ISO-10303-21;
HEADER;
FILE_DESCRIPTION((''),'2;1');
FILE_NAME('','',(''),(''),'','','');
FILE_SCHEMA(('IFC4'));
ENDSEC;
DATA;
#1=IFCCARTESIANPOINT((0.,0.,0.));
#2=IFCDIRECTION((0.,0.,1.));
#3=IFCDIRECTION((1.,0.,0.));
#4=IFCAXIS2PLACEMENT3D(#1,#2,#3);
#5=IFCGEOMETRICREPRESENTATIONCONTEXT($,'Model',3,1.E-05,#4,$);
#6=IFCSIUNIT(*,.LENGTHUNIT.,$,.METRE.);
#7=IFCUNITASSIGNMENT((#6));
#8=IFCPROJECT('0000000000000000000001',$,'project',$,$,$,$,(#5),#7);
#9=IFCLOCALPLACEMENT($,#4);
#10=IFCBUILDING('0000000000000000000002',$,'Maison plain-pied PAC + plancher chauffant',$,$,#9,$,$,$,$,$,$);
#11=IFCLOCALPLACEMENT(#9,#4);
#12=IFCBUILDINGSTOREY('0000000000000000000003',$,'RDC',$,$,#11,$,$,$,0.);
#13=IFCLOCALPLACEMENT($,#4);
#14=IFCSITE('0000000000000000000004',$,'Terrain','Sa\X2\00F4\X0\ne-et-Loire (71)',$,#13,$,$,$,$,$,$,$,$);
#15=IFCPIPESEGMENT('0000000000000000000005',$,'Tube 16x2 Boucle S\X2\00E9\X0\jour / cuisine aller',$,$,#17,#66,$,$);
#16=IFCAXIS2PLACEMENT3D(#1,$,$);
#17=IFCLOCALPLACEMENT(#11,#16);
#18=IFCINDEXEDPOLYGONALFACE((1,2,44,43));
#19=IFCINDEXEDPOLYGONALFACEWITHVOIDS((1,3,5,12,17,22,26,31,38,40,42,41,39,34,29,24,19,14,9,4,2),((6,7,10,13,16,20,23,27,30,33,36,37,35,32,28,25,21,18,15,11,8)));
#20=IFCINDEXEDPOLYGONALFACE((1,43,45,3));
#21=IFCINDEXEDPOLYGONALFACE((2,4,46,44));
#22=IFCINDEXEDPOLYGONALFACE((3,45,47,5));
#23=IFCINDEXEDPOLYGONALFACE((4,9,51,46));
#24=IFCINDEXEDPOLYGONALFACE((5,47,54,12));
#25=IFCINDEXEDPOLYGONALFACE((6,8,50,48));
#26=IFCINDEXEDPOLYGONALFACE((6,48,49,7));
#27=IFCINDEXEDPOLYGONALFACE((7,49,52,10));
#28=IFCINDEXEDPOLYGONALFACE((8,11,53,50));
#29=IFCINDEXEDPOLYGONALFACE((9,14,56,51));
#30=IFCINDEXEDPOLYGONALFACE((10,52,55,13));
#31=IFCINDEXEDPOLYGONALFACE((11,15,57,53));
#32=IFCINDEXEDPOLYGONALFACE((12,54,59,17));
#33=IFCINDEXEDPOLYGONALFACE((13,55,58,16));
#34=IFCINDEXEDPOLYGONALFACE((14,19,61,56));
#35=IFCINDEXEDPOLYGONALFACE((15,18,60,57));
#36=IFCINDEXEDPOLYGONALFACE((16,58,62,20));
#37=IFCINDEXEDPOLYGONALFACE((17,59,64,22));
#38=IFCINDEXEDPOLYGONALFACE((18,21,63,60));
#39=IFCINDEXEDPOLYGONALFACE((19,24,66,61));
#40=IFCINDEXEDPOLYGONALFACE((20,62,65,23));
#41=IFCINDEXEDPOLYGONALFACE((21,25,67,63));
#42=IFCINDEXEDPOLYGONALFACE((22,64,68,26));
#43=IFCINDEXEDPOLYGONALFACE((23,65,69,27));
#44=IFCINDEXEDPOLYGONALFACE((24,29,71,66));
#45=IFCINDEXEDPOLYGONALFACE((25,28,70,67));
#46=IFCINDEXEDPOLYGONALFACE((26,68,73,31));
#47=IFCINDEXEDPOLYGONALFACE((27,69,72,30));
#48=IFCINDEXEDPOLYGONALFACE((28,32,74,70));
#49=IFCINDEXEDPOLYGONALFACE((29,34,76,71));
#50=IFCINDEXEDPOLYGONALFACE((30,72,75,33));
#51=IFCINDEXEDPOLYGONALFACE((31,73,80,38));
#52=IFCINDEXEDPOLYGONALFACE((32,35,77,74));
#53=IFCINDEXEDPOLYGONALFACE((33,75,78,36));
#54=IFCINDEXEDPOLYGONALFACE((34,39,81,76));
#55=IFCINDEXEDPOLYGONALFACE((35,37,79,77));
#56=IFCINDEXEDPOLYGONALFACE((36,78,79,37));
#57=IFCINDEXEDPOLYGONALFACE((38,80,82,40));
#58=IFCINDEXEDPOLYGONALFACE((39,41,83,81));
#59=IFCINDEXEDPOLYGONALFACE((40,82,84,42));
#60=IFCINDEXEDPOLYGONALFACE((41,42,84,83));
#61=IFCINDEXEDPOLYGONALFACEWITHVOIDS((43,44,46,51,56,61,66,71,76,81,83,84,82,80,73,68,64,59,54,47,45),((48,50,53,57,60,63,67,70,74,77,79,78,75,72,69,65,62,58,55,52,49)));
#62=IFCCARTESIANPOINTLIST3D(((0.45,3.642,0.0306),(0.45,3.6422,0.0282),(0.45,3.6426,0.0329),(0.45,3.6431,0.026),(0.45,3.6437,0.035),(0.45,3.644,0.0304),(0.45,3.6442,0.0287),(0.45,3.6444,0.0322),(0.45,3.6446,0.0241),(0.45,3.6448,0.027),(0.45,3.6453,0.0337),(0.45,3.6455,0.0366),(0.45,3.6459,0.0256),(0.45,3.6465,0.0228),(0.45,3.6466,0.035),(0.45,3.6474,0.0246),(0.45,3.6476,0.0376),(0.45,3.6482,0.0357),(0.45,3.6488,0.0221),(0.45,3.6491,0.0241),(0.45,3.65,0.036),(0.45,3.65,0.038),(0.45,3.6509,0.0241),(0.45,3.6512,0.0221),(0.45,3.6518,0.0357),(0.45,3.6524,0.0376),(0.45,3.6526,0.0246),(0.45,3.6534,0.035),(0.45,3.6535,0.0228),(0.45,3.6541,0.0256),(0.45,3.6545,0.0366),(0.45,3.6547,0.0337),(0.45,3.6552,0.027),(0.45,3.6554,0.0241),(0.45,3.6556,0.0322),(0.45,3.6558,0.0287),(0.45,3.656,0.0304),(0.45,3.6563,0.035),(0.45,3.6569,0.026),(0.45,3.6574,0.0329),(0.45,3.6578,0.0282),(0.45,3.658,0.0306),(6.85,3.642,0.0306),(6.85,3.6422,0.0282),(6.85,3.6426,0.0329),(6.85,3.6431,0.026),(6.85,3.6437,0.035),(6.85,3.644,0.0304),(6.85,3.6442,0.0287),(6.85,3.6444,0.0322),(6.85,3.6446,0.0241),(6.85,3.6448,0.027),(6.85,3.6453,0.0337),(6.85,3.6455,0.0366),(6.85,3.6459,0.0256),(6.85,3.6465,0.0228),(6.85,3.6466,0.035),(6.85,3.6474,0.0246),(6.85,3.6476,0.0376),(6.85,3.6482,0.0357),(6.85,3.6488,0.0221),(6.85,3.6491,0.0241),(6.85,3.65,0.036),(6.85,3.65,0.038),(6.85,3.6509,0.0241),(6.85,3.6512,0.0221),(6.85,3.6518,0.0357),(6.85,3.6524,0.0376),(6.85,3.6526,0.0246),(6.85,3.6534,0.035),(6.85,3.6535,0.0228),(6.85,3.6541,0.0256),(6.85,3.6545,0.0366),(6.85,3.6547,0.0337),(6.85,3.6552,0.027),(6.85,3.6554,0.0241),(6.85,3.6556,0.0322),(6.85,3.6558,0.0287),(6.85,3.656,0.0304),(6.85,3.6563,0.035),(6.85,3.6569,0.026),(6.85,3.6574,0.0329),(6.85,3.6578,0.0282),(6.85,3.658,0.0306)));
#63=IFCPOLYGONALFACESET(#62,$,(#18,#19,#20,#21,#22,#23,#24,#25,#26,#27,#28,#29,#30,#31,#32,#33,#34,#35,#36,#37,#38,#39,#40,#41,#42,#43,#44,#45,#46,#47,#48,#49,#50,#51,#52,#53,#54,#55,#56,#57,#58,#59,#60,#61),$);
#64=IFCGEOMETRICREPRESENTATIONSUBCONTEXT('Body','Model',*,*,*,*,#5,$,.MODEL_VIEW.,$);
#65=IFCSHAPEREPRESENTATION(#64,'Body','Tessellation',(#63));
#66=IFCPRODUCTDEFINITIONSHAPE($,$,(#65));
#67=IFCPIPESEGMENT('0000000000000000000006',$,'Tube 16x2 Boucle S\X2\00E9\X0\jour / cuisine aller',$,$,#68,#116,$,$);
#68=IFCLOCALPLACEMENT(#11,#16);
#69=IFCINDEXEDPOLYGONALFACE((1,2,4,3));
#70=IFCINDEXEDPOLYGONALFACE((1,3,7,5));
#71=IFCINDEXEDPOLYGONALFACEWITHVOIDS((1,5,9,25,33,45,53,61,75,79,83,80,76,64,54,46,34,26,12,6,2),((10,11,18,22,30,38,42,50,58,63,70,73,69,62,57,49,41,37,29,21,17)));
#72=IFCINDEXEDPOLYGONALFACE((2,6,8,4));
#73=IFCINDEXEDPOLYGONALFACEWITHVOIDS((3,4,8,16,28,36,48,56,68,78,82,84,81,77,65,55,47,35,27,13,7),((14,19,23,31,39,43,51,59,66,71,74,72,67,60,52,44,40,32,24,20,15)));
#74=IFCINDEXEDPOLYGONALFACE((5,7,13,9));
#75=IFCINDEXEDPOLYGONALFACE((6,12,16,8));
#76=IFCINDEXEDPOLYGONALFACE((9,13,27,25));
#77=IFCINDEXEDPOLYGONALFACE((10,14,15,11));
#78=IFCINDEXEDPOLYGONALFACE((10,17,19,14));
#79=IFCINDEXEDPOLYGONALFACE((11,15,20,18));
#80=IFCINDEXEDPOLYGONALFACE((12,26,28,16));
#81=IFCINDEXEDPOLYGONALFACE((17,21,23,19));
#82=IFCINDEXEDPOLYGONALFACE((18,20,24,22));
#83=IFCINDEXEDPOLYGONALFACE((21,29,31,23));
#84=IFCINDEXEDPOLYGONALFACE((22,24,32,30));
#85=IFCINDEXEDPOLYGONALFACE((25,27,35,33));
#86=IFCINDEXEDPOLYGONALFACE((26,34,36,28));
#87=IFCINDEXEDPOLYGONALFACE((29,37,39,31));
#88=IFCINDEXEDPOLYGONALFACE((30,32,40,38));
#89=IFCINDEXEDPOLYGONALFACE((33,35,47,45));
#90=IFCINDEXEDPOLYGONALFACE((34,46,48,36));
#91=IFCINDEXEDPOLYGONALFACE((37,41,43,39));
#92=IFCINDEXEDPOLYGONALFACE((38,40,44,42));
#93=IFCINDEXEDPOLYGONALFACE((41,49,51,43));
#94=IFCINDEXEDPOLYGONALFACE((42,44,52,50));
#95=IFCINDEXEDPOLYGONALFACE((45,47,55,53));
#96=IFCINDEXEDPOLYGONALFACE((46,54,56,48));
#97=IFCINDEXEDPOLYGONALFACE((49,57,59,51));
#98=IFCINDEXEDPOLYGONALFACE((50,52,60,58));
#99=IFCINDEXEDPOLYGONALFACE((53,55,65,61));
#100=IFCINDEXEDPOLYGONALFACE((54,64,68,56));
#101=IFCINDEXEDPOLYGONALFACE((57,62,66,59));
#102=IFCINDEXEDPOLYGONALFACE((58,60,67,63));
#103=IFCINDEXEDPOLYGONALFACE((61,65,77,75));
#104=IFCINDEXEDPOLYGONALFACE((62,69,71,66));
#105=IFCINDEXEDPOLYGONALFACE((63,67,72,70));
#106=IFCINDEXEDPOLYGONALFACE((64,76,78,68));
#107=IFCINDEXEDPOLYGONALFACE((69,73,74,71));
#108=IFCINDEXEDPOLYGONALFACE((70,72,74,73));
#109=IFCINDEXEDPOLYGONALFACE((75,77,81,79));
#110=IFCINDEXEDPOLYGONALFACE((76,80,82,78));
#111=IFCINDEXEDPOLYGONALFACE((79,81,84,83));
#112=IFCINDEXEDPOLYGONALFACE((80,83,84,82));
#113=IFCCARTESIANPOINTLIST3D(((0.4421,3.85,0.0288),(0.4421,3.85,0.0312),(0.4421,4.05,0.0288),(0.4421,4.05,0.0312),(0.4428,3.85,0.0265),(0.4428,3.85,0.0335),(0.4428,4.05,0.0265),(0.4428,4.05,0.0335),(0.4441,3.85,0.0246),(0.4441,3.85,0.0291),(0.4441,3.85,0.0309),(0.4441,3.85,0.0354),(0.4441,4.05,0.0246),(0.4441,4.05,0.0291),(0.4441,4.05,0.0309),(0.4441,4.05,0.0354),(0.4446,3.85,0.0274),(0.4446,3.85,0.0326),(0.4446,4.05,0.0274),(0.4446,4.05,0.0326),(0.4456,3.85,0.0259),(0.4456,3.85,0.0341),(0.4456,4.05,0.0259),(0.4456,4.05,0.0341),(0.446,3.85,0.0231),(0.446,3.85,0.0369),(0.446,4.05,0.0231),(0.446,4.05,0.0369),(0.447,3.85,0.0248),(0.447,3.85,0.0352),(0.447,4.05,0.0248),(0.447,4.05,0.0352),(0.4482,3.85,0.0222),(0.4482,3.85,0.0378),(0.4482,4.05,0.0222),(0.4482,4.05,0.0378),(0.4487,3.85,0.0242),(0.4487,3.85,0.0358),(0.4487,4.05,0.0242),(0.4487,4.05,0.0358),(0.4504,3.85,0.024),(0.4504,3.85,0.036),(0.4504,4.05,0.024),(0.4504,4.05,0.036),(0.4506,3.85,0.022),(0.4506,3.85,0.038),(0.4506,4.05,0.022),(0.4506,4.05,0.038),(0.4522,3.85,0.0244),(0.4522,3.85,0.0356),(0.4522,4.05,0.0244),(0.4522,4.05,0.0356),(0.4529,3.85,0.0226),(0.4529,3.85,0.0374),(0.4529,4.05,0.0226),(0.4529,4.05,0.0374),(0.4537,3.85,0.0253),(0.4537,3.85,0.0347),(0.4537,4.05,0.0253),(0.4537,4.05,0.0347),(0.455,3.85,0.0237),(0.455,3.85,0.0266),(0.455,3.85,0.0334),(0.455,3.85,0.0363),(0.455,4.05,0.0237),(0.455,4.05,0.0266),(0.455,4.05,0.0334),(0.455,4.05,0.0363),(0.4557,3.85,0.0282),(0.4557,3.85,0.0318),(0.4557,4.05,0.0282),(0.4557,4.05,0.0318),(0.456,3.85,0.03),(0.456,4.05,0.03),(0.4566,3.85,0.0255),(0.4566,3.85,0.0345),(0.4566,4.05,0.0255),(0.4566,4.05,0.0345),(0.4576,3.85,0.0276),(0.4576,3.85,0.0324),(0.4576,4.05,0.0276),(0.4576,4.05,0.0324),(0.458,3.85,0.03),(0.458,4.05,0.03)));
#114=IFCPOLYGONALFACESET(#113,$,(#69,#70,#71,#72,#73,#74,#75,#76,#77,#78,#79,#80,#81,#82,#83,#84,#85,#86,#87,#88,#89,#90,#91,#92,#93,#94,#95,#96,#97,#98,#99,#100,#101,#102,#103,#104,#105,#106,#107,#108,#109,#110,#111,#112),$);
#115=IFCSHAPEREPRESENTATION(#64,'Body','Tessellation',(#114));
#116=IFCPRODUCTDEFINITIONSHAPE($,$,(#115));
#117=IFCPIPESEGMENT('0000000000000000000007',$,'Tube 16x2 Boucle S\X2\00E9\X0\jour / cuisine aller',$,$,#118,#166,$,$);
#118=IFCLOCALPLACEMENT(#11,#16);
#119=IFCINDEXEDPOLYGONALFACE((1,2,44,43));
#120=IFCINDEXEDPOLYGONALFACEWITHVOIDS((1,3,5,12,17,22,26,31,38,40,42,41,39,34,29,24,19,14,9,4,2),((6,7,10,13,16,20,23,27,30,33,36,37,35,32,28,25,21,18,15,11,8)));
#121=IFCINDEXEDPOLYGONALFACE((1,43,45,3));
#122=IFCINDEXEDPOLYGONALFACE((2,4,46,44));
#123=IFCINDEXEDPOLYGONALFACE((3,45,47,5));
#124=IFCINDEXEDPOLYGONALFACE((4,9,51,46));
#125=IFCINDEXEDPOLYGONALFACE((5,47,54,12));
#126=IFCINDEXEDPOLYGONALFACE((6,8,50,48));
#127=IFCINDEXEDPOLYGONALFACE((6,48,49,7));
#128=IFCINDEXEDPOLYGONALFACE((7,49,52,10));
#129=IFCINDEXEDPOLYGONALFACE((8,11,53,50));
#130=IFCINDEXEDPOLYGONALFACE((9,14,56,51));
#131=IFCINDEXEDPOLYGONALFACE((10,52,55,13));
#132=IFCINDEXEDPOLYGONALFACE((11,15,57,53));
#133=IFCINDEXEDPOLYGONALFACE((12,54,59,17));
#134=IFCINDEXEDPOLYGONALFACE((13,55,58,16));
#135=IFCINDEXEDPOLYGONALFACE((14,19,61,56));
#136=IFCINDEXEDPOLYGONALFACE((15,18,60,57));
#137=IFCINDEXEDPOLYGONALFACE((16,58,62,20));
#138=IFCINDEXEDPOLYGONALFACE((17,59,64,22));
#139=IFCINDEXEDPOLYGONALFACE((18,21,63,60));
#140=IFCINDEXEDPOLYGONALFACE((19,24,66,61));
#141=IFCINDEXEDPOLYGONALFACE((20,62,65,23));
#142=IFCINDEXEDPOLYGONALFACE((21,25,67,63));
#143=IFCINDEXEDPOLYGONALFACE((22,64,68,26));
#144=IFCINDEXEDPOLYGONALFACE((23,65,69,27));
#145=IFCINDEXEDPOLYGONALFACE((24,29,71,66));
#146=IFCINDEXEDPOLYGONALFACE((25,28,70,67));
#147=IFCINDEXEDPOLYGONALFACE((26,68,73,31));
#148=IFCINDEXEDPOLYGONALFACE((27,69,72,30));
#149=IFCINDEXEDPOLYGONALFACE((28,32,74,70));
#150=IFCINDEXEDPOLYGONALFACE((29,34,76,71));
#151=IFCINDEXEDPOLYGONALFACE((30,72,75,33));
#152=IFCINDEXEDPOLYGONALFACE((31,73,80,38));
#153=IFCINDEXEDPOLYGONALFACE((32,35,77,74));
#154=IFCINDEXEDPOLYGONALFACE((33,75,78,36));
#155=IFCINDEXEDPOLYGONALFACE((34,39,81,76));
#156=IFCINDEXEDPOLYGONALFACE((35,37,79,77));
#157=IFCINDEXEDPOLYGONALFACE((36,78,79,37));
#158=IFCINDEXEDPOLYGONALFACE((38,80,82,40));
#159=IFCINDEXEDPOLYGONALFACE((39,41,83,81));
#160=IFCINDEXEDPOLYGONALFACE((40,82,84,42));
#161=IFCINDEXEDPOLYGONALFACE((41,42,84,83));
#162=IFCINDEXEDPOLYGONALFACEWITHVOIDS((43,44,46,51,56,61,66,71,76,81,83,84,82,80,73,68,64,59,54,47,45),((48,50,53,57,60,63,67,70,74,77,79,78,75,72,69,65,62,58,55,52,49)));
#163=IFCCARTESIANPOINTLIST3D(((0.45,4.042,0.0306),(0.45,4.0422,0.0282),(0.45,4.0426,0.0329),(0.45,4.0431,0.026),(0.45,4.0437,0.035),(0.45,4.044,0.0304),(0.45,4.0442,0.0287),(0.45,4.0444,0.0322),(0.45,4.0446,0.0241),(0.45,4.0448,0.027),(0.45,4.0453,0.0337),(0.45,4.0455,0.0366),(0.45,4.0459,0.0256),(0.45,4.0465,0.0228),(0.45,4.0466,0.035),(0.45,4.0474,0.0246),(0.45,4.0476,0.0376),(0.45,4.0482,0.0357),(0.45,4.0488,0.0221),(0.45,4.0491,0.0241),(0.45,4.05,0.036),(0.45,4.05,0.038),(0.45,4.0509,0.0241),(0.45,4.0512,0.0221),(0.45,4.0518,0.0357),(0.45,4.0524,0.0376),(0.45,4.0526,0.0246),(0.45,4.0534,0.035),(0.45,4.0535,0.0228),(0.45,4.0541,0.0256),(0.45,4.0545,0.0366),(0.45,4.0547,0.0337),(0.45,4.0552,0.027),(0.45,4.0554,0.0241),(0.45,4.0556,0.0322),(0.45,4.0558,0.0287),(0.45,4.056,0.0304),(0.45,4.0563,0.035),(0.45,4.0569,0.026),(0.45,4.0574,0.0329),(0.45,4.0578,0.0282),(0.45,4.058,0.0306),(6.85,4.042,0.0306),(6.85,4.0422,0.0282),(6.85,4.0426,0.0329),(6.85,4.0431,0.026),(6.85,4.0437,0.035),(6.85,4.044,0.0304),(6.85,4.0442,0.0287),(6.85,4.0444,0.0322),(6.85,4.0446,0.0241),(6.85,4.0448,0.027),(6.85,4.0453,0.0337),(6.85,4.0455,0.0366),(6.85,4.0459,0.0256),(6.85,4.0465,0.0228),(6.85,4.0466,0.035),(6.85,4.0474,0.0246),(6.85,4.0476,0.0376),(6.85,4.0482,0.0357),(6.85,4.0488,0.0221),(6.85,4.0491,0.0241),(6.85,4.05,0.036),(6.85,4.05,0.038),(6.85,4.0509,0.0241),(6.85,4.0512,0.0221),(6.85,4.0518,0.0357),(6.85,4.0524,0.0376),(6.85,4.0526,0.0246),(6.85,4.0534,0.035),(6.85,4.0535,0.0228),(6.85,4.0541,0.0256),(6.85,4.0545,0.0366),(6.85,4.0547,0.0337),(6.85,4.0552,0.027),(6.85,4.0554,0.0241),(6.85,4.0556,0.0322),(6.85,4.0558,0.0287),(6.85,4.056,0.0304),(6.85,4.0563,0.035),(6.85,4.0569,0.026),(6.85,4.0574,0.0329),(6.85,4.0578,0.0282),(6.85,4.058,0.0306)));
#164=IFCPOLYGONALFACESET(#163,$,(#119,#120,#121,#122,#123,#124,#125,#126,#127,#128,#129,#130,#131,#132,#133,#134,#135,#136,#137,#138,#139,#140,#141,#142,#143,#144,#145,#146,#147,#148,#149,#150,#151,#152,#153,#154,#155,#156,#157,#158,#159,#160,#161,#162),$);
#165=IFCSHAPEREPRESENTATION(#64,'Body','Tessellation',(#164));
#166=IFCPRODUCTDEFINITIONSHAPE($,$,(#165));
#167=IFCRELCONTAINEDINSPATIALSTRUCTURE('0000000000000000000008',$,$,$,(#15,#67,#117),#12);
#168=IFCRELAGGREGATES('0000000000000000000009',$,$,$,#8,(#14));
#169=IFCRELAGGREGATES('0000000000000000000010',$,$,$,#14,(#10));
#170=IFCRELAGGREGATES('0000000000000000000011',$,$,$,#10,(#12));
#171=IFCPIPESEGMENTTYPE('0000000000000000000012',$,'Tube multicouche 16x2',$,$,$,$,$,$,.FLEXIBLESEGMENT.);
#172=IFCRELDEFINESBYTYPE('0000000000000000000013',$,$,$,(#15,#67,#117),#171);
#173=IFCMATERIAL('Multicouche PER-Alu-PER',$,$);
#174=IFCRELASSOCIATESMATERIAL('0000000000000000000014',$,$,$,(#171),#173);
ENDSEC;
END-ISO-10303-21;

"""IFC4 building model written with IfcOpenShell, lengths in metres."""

from ifc_helpers import new_model, si_unit, frame, origin_with_axes, place, context, subcontext, project, spatial, hollow_circle, extrude, material, type_object, element, save


model = new_model("IFC4")

# Units and contexts
model_context = context("Model", 3, precision=1e-05, world=origin_with_axes())
body_context = subcontext(model_context, "Body", "Model", "MODEL_VIEW")
ifc_project = project(units=[si_unit("LENGTHUNIT", "METRE")], contexts=[model_context])

# Site, building, storey
site_placement = place(None, origin_with_axes())
site = spatial("IfcSite", under=ifc_project, at=site_placement, Name="Terrain", Description="Saône-et-Loire (71)")
building_placement = place(None, origin_with_axes())
building = spatial("IfcBuilding", under=site, at=building_placement, Name="Maison plain-pied PAC + plancher chauffant")
storey_placement = place(building_placement, origin_with_axes())
storey = spatial("IfcBuildingStorey", under=building, at=storey_placement, Name="RDC", Elevation=0.0)

# Pipe segments
ifc_material = material(Name="Multicouche PER-Alu-PER")
pipe_segment_type = type_object("IfcPipeSegmentType", Name="Tube multicouche 16x2", PredefinedType="FLEXIBLESEGMENT", material=ifc_material)
pipe_segment_1_placement = place(storey_placement, frame((0.45, 3.65, 0.03), z_axis=(1.0, 0.0, 0.0), x_axis=(0.0, 0.0, 1.0)))
element("IfcPipeSegment", 1, at=pipe_segment_1_placement, inside=storey, type_object=pipe_segment_type, Name="Tube 16x2 Boucle Séjour / cuisine aller", context=body_context, shape_type="SweptSolid", body=[
    extrude(hollow_circle(Radius=0.008, WallThickness=0.002), origin_with_axes(), (0.0, 0.0, 1.0), 6.4),
])
pipe_segment_2_placement = place(storey_placement, frame((0.45, 3.85, 0.03), z_axis=(0.0, 1.0, 0.0), x_axis=(1.0, 0.0, 0.0)))
element("IfcPipeSegment", 2, at=pipe_segment_2_placement, inside=storey, type_object=pipe_segment_type, Name="Tube 16x2 Boucle Séjour / cuisine aller", context=body_context, shape_type="SweptSolid", body=[
    extrude(hollow_circle(Radius=0.008, WallThickness=0.002), origin_with_axes(), (0.0, 0.0, 1.0), 0.2),
])
pipe_segment_3_placement = place(storey_placement, frame((0.45, 4.05, 0.03), z_axis=(1.0, 0.0, 0.0), x_axis=(0.0, 0.0, 1.0)))
element("IfcPipeSegment", 3, at=pipe_segment_3_placement, inside=storey, type_object=pipe_segment_type, Name="Tube 16x2 Boucle Séjour / cuisine aller", context=body_context, shape_type="SweptSolid", body=[
    extrude(hollow_circle(Radius=0.008, WallThickness=0.002), origin_with_axes(), (0.0, 0.0, 1.0), 6.4),
])

save(model, "model.ifc")
